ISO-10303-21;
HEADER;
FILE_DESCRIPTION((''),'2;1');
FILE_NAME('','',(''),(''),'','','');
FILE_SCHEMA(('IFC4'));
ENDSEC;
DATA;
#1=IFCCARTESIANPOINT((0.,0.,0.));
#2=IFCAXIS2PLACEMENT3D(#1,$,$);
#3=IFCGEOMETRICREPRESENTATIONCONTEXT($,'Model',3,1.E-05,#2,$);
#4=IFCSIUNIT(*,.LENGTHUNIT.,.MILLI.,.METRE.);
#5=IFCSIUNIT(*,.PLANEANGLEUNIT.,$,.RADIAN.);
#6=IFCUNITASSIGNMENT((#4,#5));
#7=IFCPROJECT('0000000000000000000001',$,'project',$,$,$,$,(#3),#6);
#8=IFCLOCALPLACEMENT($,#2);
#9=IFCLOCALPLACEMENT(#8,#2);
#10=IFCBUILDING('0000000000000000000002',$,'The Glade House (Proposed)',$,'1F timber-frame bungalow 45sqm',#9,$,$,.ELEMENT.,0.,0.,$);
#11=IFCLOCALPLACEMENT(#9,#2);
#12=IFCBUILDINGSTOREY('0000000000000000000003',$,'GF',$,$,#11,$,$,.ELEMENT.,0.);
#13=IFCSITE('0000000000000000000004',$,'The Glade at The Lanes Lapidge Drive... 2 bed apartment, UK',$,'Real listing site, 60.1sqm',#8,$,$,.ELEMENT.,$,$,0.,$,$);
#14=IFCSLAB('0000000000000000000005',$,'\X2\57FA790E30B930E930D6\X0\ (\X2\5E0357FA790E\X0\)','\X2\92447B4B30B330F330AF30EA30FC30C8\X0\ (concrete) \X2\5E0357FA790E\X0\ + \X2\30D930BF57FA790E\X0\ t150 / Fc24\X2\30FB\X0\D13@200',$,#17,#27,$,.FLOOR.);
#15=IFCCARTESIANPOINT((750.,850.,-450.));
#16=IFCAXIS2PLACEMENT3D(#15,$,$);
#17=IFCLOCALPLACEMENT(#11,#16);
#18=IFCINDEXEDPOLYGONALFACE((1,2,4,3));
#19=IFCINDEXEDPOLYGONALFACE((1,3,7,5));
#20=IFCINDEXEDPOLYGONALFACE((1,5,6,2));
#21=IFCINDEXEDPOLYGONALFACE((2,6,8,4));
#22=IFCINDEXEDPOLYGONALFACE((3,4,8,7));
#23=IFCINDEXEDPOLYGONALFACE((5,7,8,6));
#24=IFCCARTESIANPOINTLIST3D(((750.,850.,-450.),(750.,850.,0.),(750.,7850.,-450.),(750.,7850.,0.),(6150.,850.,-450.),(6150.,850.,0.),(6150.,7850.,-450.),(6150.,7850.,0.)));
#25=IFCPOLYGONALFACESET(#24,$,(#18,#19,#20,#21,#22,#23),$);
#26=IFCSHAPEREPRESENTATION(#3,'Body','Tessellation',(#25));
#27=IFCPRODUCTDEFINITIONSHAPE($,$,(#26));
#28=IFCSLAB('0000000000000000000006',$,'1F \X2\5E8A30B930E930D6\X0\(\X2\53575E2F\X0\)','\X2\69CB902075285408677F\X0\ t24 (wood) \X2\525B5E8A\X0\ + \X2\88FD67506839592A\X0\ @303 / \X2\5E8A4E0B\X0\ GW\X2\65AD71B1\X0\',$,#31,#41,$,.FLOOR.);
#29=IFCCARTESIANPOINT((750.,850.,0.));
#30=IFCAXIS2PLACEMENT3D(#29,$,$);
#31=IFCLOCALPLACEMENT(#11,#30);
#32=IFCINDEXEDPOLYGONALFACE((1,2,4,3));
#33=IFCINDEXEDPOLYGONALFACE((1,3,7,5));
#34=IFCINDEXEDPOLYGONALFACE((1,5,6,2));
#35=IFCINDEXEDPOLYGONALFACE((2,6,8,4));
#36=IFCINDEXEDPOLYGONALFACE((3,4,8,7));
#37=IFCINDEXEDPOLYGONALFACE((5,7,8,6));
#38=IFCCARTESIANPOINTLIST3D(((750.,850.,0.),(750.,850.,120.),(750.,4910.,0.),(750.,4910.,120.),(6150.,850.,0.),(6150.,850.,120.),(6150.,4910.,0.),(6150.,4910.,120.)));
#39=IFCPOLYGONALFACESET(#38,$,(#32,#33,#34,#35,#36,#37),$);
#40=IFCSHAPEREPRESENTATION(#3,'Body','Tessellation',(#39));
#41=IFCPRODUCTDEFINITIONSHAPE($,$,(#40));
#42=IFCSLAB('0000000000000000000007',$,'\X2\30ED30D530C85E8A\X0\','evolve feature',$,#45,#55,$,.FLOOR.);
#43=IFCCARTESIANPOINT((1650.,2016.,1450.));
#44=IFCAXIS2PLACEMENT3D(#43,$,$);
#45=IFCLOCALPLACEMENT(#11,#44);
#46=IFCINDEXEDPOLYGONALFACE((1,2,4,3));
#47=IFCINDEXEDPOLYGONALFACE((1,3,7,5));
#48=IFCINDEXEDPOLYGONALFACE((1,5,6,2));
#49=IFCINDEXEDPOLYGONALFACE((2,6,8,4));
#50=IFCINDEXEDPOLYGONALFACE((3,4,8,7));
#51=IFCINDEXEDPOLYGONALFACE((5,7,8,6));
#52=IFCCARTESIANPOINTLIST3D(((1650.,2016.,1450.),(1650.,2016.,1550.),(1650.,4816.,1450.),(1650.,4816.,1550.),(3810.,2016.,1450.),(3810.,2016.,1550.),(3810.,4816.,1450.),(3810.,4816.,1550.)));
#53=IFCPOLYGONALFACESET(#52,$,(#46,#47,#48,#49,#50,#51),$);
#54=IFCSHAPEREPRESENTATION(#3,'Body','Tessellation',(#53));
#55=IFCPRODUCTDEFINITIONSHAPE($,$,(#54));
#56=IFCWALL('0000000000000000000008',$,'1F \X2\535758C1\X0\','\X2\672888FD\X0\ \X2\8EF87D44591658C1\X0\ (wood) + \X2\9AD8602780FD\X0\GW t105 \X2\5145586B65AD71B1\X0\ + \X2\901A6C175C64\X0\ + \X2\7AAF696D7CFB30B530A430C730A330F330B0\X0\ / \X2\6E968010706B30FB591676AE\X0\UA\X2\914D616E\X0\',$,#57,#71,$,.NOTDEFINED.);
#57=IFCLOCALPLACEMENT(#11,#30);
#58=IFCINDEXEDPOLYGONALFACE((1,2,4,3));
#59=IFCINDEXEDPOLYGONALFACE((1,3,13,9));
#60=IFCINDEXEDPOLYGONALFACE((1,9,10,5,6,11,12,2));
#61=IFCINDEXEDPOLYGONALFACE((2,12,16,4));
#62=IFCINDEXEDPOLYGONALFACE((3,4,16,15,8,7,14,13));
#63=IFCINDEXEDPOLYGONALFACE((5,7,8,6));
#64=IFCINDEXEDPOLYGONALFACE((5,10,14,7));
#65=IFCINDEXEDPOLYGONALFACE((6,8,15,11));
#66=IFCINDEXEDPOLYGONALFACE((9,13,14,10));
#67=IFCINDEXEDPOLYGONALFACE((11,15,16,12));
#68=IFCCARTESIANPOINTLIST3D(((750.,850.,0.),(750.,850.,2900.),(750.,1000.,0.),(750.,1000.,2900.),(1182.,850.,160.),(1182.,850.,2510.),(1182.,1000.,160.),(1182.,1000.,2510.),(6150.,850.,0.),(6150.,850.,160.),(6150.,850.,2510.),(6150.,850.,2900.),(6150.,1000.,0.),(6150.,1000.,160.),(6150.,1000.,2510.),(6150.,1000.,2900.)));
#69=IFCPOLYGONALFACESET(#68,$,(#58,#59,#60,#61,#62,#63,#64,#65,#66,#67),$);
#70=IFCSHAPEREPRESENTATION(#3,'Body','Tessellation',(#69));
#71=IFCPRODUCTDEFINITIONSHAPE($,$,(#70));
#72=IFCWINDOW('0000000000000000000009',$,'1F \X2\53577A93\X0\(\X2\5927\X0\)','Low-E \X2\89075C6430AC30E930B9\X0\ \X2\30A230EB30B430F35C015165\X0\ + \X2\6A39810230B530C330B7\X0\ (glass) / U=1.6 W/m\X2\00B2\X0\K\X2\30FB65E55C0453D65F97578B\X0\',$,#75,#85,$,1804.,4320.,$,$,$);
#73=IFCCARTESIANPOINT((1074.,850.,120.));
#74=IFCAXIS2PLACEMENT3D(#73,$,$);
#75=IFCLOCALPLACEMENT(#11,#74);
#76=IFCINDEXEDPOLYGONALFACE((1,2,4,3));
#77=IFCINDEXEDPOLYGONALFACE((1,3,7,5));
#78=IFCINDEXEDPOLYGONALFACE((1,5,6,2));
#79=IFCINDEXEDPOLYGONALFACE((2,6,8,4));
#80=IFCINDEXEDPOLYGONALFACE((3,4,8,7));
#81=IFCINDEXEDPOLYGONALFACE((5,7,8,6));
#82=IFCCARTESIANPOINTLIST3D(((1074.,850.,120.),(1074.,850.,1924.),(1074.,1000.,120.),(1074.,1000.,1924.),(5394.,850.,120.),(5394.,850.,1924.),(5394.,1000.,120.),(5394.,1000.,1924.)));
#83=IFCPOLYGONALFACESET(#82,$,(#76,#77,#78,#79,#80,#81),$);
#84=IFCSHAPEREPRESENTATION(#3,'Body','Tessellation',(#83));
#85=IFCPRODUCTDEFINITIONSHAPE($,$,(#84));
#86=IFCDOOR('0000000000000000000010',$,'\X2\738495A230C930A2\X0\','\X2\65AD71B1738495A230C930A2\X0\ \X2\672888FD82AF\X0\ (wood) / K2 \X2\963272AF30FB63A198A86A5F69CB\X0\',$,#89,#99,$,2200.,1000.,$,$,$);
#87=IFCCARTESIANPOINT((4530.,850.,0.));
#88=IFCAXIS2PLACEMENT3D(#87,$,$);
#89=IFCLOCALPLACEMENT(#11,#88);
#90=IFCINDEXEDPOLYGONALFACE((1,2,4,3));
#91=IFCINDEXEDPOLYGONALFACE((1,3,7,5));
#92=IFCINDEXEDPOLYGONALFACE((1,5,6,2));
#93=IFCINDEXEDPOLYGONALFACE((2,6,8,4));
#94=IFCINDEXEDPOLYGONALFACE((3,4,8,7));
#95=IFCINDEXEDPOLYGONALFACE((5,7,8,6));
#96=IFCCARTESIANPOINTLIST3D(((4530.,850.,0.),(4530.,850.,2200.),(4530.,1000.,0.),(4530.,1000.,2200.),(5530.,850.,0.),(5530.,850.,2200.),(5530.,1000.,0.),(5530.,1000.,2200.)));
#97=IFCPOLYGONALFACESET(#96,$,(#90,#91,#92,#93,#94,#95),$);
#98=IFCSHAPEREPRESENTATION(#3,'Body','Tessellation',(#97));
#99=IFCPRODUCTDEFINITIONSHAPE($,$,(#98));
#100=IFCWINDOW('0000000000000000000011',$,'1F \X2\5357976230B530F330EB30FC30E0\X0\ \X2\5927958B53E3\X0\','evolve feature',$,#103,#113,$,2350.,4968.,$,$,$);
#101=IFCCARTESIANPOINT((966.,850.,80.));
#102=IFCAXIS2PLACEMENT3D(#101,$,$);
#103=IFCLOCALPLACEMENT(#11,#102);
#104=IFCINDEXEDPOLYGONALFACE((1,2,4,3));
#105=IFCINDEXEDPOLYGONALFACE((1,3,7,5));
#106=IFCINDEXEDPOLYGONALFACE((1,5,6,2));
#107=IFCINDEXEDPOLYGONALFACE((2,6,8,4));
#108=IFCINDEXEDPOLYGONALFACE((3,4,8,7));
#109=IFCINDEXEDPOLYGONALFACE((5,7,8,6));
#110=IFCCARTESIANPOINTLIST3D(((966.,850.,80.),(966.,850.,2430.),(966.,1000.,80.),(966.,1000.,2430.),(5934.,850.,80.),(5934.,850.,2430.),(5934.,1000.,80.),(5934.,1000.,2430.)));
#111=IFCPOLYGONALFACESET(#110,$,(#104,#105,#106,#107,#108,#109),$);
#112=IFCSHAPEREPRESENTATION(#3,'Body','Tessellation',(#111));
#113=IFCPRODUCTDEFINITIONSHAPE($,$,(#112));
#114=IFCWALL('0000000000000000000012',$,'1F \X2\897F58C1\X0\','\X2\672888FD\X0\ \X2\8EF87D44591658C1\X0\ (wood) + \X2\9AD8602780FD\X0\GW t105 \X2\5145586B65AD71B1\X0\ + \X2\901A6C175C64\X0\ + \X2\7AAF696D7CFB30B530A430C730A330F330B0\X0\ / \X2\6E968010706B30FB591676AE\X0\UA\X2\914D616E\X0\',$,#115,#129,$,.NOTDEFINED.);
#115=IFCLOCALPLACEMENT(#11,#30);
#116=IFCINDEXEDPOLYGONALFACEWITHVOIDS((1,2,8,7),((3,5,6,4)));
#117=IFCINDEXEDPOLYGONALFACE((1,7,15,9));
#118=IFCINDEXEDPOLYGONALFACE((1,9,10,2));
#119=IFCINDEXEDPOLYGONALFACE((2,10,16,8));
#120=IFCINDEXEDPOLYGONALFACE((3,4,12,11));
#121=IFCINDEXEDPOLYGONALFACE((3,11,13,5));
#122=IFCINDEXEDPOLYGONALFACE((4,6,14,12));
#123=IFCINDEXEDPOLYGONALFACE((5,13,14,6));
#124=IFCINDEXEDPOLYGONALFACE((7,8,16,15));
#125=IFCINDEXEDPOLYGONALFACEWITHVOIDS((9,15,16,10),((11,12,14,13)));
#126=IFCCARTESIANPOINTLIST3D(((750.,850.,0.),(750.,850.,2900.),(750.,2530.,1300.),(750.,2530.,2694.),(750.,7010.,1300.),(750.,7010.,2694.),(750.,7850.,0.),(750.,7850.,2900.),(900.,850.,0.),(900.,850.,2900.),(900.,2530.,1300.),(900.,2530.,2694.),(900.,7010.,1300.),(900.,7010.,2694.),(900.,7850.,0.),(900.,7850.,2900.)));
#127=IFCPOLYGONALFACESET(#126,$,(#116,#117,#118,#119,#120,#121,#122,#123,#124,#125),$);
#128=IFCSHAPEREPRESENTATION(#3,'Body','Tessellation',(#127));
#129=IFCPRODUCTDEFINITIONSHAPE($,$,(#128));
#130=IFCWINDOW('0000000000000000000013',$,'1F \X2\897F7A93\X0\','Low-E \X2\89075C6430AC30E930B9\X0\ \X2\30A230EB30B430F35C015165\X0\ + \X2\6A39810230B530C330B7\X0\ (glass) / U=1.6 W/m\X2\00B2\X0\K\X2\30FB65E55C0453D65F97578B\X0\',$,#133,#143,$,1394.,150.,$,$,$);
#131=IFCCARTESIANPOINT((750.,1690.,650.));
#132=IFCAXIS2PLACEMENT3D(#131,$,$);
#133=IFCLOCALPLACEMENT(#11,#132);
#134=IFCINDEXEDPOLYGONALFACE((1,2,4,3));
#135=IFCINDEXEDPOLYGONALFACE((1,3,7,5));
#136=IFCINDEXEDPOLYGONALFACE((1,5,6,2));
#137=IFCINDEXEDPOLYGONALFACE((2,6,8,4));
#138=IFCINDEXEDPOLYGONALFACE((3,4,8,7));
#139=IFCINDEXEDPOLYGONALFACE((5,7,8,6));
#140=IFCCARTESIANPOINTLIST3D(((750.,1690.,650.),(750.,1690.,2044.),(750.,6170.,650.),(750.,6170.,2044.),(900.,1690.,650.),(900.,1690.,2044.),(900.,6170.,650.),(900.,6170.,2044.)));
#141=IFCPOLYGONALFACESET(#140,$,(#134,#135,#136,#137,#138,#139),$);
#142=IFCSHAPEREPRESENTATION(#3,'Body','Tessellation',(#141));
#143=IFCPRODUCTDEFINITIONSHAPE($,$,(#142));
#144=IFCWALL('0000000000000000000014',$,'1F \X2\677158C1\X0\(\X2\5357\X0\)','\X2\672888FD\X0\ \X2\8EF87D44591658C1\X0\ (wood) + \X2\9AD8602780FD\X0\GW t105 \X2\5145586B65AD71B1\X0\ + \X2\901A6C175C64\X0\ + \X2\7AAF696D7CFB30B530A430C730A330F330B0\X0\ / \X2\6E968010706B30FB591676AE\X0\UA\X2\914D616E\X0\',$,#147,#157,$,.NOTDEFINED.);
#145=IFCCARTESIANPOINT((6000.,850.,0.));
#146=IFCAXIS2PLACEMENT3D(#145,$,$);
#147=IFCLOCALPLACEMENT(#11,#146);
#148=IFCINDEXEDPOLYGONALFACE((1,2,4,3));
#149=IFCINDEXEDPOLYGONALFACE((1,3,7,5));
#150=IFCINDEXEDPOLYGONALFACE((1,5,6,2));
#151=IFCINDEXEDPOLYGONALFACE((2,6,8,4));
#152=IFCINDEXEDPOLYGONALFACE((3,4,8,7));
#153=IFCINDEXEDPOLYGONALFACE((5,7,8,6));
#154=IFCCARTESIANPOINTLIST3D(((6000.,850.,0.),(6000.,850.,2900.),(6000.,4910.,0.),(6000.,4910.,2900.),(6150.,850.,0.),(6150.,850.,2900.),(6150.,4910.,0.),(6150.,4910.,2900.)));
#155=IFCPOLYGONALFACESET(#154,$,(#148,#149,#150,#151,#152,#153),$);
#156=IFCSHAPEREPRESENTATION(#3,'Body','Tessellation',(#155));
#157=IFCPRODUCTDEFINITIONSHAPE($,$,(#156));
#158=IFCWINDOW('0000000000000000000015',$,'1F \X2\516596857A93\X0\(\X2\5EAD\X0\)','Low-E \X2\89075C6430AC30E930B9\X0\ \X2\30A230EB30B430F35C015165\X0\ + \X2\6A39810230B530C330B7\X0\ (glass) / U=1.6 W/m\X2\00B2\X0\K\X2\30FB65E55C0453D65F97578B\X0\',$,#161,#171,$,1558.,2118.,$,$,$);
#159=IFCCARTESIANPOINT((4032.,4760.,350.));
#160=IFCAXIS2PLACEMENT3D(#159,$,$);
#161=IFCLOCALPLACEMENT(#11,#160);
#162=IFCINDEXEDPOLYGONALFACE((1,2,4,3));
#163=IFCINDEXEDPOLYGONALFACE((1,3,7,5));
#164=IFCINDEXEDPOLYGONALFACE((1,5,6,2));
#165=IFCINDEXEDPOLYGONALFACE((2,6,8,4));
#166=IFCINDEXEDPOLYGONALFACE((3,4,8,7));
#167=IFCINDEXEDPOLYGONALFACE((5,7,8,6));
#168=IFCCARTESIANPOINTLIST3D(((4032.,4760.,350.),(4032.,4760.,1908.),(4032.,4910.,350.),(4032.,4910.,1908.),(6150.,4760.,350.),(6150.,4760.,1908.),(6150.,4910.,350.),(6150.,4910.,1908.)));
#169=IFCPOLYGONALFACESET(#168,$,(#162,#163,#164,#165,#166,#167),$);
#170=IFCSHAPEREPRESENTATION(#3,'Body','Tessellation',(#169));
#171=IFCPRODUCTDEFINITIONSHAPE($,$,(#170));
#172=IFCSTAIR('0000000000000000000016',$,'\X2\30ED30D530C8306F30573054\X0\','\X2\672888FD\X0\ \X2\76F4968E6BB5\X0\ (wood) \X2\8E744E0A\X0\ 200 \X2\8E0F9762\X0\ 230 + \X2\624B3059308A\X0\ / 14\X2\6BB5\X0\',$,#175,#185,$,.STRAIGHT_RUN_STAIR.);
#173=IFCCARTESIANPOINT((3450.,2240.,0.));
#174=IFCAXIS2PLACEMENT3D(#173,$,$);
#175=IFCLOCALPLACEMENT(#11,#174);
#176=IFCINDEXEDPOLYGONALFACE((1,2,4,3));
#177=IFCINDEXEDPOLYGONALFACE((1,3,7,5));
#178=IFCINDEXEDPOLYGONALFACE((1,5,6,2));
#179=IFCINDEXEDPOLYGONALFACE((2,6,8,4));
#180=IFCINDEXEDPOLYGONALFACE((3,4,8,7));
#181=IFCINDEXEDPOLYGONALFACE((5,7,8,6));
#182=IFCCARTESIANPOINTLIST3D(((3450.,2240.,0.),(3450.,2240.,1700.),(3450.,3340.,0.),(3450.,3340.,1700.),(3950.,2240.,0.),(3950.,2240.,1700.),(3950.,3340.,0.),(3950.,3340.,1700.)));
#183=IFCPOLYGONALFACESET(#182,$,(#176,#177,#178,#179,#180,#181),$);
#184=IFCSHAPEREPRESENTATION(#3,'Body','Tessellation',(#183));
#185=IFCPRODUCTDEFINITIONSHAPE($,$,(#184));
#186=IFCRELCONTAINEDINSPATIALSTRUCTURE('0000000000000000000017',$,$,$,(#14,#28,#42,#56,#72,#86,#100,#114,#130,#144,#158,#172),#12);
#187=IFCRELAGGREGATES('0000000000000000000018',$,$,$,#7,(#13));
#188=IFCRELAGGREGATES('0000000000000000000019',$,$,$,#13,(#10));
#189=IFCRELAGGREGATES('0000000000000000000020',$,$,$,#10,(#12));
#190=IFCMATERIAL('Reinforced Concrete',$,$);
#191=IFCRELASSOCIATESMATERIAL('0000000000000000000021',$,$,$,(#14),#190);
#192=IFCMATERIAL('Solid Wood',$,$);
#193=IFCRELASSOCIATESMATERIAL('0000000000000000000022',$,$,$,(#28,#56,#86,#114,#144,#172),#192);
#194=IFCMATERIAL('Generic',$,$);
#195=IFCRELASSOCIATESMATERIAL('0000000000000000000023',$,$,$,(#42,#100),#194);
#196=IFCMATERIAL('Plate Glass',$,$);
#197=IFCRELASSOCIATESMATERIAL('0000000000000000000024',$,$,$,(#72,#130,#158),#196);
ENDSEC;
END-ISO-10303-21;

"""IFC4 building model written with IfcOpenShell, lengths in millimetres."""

from ifc_helpers import new_model, si_unit, frame, frame_2d, origin, place, context, project, spatial, rectangle, extrude, material, element, fill, save


model = new_model("IFC4")

# Units and contexts
model_context = context("Model", 3, precision=1e-05, world=origin())
ifc_project = project(units=[si_unit("LENGTHUNIT", "METRE", prefix="MILLI"), si_unit("PLANEANGLEUNIT", "RADIAN")], contexts=[model_context])

# Site, building, storey
site_placement = place(None, origin())
site = spatial("IfcSite", under=ifc_project, at=site_placement, Name="The Glade at The Lanes Lapidge Drive... 2 bed apartment, UK", ObjectType="Real listing site, 60.1sqm", CompositionType="ELEMENT", RefElevation=0.0)
building_placement = place(site_placement, origin())
building = spatial("IfcBuilding", under=site, at=building_placement, Name="The Glade House (Proposed)", ObjectType="1F timber-frame bungalow 45sqm", CompositionType="ELEMENT", ElevationOfRefHeight=0.0, ElevationOfTerrain=0.0)
storey_placement = place(building_placement, origin())
storey = spatial("IfcBuildingStorey", under=building, at=storey_placement, Name="GF", CompositionType="ELEMENT", Elevation=0.0)

# Slabs
ifc_material_1 = material(Name="Reinforced Concrete")
slab_1_placement = place(storey_placement, frame((750.0, 850.0, -450.0)))
element("IfcSlab", 1, at=slab_1_placement, inside=storey, material=ifc_material_1, Name="基礎スラブ (布基礎)", Description="鉄筋コンクリート (concrete) 布基礎 + ベタ基礎 t150 / Fc24・D13@200", PredefinedType="FLOOR", context=model_context, shape_type="SweptSolid", body=[
    extrude(rectangle(XDim=5400.0, YDim=7000.0, at=frame_2d((2700.0, 3500.0))), frame((750.0, 850.0, -450.0)), (0.0, 0.0, 1.0), 450.0),
])
ifc_material_2 = material(Name="Solid Wood")
slab_2_placement = place(storey_placement, frame((750.0, 850.0, 0.0)))
element("IfcSlab", 2, at=slab_2_placement, inside=storey, material=ifc_material_2, Name="1F 床スラブ(南帯)", Description="構造用合板 t24 (wood) 剛床 + 製材根太 @303 / 床下 GW断熱", PredefinedType="FLOOR", context=model_context, shape_type="SweptSolid", body=[
    extrude(rectangle(XDim=5400.0, YDim=4060.0, at=frame_2d((2700.0, 2030.0))), frame((750.0, 850.0, 0.0)), (0.0, 0.0, 1.0), 120.0),
])
ifc_material_3 = material(Name="Generic")
slab_3_placement = place(storey_placement, frame((1650.0, 2016.0, 1450.0)))
element("IfcSlab", 3, at=slab_3_placement, inside=storey, material=ifc_material_3, Name="ロフト床", Description="evolve feature", PredefinedType="FLOOR", context=model_context, shape_type="SweptSolid", body=[
    extrude(rectangle(XDim=2160.0, YDim=2800.0, at=frame_2d((1080.0, 1400.0))), frame((1650.0, 2016.0, 1450.0)), (0.0, 0.0, 1.0), 100.0),
])

# Wall, openings, windows, door
wall_1_placement = place(storey_placement, frame((750.0, 850.0, 0.0)))
wall_1 = element("IfcWall", 4, at=wall_1_placement, inside=storey, material=ifc_material_2, Name="1F 南壁", Description="木製 軸組外壁 (wood) + 高性能GW t105 充填断熱 + 通気層 + 窯業系サイディング / 準耐火・外皮UA配慮", PredefinedType="NOTDEFINED", context=model_context, shape_type="SweptSolid", body=[
    extrude(rectangle(XDim=5400.0, YDim=150.0, at=frame_2d((2700.0, 75.0))), frame((750.0, 850.0, 0.0)), (0.0, 0.0, 1.0), 2900.0),
])
opening_1_placement = place(storey_placement, frame((1074.0, 850.0, 120.0)))
opening_1 = element("IfcOpeningElement", 5, at=opening_1_placement, cuts=wall_1, PredefinedType="NOTDEFINED", context=model_context, shape_type="SweptSolid", body=[
    extrude(rectangle(XDim=4320.0, YDim=150.0, at=frame_2d((2160.0, 75.0))), frame((1074.0, 850.0, 120.0)), (0.0, 0.0, 1.0), 1804.0),
])
opening_2_placement = place(storey_placement, frame((4530.0, 850.0, 0.0)))
opening_2 = element("IfcOpeningElement", 6, at=opening_2_placement, cuts=wall_1, PredefinedType="NOTDEFINED", context=model_context, shape_type="SweptSolid", body=[
    extrude(rectangle(XDim=1000.0, YDim=150.0, at=frame_2d((500.0, 75.0))), frame((4530.0, 850.0, 0.0)), (0.0, 0.0, 1.0), 2200.0),
])
opening_3_placement = place(storey_placement, frame((966.0, 850.0, 80.0)))
opening_3 = element("IfcOpeningElement", 7, at=opening_3_placement, cuts=wall_1, PredefinedType="NOTDEFINED", context=model_context, shape_type="SweptSolid", body=[
    extrude(rectangle(XDim=4968.0, YDim=150.0, at=frame_2d((2484.0, 75.0))), frame((966.0, 850.0, 80.0)), (0.0, 0.0, 1.0), 2350.0),
])
ifc_material_4 = material(Name="Plate Glass")
window_1_placement = place(storey_placement, frame((1074.0, 850.0, 120.0)))
window_1 = element("IfcWindow", 8, at=window_1_placement, inside=storey, material=ifc_material_4, Name="1F 南窓(大)", Description="Low-E 複層ガラス アルゴン封入 + 樹脂サッシ (glass) / U=1.6 W/m²K・日射取得型", OverallHeight=1804.0, OverallWidth=4320.0, context=model_context, shape_type="SweptSolid", body=[
    extrude(rectangle(XDim=4320.0, YDim=150.0, at=frame_2d((2160.0, 75.0))), frame((1074.0, 850.0, 120.0)), (0.0, 0.0, 1.0), 1804.0),
])
fill(opening_1, window_1)
door_1_placement = place(storey_placement, frame((4530.0, 850.0, 0.0)))
door_1 = element("IfcDoor", 9, at=door_1_placement, inside=storey, material=ifc_material_2, Name="玄関ドア", Description="断熱玄関ドア 木製芯 (wood) / K2 防犯・採風機構", OverallHeight=2200.0, OverallWidth=1000.0, context=model_context, shape_type="SweptSolid", body=[
    extrude(rectangle(XDim=1000.0, YDim=150.0, at=frame_2d((500.0, 75.0))), frame((4530.0, 850.0, 0.0)), (0.0, 0.0, 1.0), 2200.0),
])
fill(opening_2, door_1)
window_2_placement = place(storey_placement, frame((966.0, 850.0, 80.0)))
window_2 = element("IfcWindow", 10, at=window_2_placement, inside=storey, material=ifc_material_3, Name="1F 南面サンルーム 大開口", Description="evolve feature", OverallHeight=2350.0, OverallWidth=4968.0, context=model_context, shape_type="SweptSolid", body=[
    extrude(rectangle(XDim=4968.0, YDim=150.0, at=frame_2d((2484.0, 75.0))), frame((966.0, 850.0, 80.0)), (0.0, 0.0, 1.0), 2350.0),
])
fill(opening_3, window_2)

# Walls, openings, windows
wall_2_placement = place(storey_placement, frame((750.0, 850.0, 0.0)))
wall_2 = element("IfcWall", 11, at=wall_2_placement, inside=storey, material=ifc_material_2, Name="1F 西壁", Description="木製 軸組外壁 (wood) + 高性能GW t105 充填断熱 + 通気層 + 窯業系サイディング / 準耐火・外皮UA配慮", PredefinedType="NOTDEFINED", context=model_context, shape_type="SweptSolid", body=[
    extrude(rectangle(XDim=150.0, YDim=7000.0, at=frame_2d((75.0, 3500.0))), frame((750.0, 850.0, 0.0)), (0.0, 0.0, 1.0), 2900.0),
])
opening_4_placement = place(storey_placement, frame((750.0, 1690.0, 650.0)))
opening_4 = element("IfcOpeningElement", 12, at=opening_4_placement, cuts=wall_2, PredefinedType="NOTDEFINED", context=model_context, shape_type="SweptSolid", body=[
    extrude(rectangle(XDim=150.0, YDim=4480.0, at=frame_2d((75.0, 2240.0))), frame((750.0, 1690.0, 650.0)), (0.0, 0.0, 1.0), 1394.0),
])
window_3_placement = place(storey_placement, frame((750.0, 1690.0, 650.0)))
window_3 = element("IfcWindow", 13, at=window_3_placement, inside=storey, material=ifc_material_4, Name="1F 西窓", Description="Low-E 複層ガラス アルゴン封入 + 樹脂サッシ (glass) / U=1.6 W/m²K・日射取得型", OverallHeight=1394.0, OverallWidth=150.0, context=model_context, shape_type="SweptSolid", body=[
    extrude(rectangle(XDim=150.0, YDim=4480.0, at=frame_2d((75.0, 2240.0))), frame((750.0, 1690.0, 650.0)), (0.0, 0.0, 1.0), 1394.0),
])
fill(opening_4, window_3)
wall_3_placement = place(storey_placement, frame((6000.0, 850.0, 0.0)))
wall_3 = element("IfcWall", 14, at=wall_3_placement, inside=storey, material=ifc_material_2, Name="1F 東壁(南)", Description="木製 軸組外壁 (wood) + 高性能GW t105 充填断熱 + 通気層 + 窯業系サイディング / 準耐火・外皮UA配慮", PredefinedType="NOTDEFINED", context=model_context, shape_type="SweptSolid", body=[
    extrude(rectangle(XDim=150.0, YDim=4060.0, at=frame_2d((75.0, 2030.0))), frame((6000.0, 850.0, 0.0)), (0.0, 0.0, 1.0), 2900.0),
])
opening_5_placement = place(storey_placement, frame((4032.0, 4760.0, 350.0)))
opening_5 = element("IfcOpeningElement", 15, at=opening_5_placement, cuts=wall_3, PredefinedType="NOTDEFINED", context=model_context, shape_type="SweptSolid", body=[
    extrude(rectangle(XDim=2118.0, YDim=150.0, at=frame_2d((1059.0, 75.0))), frame((4032.0, 4760.0, 350.0)), (0.0, 0.0, 1.0), 1558.0),
])
window_4_placement = place(storey_placement, frame((4032.0, 4760.0, 350.0)))
window_4 = element("IfcWindow", 16, at=window_4_placement, inside=storey, material=ifc_material_4, Name="1F 入隅窓(庭)", Description="Low-E 複層ガラス アルゴン封入 + 樹脂サッシ (glass) / U=1.6 W/m²K・日射取得型", OverallHeight=1558.0, OverallWidth=2118.0, context=model_context, shape_type="SweptSolid", body=[
    extrude(rectangle(XDim=2118.0, YDim=150.0, at=frame_2d((1059.0, 75.0))), frame((4032.0, 4760.0, 350.0)), (0.0, 0.0, 1.0), 1558.0),
])
fill(opening_5, window_4)

# Stair
stair_placement = place(storey_placement, frame((3450.0, 2240.0, 0.0)))
element("IfcStair", 17, at=stair_placement, inside=storey, material=ifc_material_2, Name="ロフトはしご", Description="木製 直階段 (wood) 蹴上 200 踏面 230 + 手すり / 14段", PredefinedType="STRAIGHT_RUN_STAIR", context=model_context, shape_type="SweptSolid", body=[
    extrude(rectangle(XDim=500.0, YDim=1100.0, at=frame_2d((250.0, 550.0))), frame((3450.0, 2240.0, 0.0)), (0.0, 0.0, 1.0), 1700.0),
])

save(model, "model.ifc")
